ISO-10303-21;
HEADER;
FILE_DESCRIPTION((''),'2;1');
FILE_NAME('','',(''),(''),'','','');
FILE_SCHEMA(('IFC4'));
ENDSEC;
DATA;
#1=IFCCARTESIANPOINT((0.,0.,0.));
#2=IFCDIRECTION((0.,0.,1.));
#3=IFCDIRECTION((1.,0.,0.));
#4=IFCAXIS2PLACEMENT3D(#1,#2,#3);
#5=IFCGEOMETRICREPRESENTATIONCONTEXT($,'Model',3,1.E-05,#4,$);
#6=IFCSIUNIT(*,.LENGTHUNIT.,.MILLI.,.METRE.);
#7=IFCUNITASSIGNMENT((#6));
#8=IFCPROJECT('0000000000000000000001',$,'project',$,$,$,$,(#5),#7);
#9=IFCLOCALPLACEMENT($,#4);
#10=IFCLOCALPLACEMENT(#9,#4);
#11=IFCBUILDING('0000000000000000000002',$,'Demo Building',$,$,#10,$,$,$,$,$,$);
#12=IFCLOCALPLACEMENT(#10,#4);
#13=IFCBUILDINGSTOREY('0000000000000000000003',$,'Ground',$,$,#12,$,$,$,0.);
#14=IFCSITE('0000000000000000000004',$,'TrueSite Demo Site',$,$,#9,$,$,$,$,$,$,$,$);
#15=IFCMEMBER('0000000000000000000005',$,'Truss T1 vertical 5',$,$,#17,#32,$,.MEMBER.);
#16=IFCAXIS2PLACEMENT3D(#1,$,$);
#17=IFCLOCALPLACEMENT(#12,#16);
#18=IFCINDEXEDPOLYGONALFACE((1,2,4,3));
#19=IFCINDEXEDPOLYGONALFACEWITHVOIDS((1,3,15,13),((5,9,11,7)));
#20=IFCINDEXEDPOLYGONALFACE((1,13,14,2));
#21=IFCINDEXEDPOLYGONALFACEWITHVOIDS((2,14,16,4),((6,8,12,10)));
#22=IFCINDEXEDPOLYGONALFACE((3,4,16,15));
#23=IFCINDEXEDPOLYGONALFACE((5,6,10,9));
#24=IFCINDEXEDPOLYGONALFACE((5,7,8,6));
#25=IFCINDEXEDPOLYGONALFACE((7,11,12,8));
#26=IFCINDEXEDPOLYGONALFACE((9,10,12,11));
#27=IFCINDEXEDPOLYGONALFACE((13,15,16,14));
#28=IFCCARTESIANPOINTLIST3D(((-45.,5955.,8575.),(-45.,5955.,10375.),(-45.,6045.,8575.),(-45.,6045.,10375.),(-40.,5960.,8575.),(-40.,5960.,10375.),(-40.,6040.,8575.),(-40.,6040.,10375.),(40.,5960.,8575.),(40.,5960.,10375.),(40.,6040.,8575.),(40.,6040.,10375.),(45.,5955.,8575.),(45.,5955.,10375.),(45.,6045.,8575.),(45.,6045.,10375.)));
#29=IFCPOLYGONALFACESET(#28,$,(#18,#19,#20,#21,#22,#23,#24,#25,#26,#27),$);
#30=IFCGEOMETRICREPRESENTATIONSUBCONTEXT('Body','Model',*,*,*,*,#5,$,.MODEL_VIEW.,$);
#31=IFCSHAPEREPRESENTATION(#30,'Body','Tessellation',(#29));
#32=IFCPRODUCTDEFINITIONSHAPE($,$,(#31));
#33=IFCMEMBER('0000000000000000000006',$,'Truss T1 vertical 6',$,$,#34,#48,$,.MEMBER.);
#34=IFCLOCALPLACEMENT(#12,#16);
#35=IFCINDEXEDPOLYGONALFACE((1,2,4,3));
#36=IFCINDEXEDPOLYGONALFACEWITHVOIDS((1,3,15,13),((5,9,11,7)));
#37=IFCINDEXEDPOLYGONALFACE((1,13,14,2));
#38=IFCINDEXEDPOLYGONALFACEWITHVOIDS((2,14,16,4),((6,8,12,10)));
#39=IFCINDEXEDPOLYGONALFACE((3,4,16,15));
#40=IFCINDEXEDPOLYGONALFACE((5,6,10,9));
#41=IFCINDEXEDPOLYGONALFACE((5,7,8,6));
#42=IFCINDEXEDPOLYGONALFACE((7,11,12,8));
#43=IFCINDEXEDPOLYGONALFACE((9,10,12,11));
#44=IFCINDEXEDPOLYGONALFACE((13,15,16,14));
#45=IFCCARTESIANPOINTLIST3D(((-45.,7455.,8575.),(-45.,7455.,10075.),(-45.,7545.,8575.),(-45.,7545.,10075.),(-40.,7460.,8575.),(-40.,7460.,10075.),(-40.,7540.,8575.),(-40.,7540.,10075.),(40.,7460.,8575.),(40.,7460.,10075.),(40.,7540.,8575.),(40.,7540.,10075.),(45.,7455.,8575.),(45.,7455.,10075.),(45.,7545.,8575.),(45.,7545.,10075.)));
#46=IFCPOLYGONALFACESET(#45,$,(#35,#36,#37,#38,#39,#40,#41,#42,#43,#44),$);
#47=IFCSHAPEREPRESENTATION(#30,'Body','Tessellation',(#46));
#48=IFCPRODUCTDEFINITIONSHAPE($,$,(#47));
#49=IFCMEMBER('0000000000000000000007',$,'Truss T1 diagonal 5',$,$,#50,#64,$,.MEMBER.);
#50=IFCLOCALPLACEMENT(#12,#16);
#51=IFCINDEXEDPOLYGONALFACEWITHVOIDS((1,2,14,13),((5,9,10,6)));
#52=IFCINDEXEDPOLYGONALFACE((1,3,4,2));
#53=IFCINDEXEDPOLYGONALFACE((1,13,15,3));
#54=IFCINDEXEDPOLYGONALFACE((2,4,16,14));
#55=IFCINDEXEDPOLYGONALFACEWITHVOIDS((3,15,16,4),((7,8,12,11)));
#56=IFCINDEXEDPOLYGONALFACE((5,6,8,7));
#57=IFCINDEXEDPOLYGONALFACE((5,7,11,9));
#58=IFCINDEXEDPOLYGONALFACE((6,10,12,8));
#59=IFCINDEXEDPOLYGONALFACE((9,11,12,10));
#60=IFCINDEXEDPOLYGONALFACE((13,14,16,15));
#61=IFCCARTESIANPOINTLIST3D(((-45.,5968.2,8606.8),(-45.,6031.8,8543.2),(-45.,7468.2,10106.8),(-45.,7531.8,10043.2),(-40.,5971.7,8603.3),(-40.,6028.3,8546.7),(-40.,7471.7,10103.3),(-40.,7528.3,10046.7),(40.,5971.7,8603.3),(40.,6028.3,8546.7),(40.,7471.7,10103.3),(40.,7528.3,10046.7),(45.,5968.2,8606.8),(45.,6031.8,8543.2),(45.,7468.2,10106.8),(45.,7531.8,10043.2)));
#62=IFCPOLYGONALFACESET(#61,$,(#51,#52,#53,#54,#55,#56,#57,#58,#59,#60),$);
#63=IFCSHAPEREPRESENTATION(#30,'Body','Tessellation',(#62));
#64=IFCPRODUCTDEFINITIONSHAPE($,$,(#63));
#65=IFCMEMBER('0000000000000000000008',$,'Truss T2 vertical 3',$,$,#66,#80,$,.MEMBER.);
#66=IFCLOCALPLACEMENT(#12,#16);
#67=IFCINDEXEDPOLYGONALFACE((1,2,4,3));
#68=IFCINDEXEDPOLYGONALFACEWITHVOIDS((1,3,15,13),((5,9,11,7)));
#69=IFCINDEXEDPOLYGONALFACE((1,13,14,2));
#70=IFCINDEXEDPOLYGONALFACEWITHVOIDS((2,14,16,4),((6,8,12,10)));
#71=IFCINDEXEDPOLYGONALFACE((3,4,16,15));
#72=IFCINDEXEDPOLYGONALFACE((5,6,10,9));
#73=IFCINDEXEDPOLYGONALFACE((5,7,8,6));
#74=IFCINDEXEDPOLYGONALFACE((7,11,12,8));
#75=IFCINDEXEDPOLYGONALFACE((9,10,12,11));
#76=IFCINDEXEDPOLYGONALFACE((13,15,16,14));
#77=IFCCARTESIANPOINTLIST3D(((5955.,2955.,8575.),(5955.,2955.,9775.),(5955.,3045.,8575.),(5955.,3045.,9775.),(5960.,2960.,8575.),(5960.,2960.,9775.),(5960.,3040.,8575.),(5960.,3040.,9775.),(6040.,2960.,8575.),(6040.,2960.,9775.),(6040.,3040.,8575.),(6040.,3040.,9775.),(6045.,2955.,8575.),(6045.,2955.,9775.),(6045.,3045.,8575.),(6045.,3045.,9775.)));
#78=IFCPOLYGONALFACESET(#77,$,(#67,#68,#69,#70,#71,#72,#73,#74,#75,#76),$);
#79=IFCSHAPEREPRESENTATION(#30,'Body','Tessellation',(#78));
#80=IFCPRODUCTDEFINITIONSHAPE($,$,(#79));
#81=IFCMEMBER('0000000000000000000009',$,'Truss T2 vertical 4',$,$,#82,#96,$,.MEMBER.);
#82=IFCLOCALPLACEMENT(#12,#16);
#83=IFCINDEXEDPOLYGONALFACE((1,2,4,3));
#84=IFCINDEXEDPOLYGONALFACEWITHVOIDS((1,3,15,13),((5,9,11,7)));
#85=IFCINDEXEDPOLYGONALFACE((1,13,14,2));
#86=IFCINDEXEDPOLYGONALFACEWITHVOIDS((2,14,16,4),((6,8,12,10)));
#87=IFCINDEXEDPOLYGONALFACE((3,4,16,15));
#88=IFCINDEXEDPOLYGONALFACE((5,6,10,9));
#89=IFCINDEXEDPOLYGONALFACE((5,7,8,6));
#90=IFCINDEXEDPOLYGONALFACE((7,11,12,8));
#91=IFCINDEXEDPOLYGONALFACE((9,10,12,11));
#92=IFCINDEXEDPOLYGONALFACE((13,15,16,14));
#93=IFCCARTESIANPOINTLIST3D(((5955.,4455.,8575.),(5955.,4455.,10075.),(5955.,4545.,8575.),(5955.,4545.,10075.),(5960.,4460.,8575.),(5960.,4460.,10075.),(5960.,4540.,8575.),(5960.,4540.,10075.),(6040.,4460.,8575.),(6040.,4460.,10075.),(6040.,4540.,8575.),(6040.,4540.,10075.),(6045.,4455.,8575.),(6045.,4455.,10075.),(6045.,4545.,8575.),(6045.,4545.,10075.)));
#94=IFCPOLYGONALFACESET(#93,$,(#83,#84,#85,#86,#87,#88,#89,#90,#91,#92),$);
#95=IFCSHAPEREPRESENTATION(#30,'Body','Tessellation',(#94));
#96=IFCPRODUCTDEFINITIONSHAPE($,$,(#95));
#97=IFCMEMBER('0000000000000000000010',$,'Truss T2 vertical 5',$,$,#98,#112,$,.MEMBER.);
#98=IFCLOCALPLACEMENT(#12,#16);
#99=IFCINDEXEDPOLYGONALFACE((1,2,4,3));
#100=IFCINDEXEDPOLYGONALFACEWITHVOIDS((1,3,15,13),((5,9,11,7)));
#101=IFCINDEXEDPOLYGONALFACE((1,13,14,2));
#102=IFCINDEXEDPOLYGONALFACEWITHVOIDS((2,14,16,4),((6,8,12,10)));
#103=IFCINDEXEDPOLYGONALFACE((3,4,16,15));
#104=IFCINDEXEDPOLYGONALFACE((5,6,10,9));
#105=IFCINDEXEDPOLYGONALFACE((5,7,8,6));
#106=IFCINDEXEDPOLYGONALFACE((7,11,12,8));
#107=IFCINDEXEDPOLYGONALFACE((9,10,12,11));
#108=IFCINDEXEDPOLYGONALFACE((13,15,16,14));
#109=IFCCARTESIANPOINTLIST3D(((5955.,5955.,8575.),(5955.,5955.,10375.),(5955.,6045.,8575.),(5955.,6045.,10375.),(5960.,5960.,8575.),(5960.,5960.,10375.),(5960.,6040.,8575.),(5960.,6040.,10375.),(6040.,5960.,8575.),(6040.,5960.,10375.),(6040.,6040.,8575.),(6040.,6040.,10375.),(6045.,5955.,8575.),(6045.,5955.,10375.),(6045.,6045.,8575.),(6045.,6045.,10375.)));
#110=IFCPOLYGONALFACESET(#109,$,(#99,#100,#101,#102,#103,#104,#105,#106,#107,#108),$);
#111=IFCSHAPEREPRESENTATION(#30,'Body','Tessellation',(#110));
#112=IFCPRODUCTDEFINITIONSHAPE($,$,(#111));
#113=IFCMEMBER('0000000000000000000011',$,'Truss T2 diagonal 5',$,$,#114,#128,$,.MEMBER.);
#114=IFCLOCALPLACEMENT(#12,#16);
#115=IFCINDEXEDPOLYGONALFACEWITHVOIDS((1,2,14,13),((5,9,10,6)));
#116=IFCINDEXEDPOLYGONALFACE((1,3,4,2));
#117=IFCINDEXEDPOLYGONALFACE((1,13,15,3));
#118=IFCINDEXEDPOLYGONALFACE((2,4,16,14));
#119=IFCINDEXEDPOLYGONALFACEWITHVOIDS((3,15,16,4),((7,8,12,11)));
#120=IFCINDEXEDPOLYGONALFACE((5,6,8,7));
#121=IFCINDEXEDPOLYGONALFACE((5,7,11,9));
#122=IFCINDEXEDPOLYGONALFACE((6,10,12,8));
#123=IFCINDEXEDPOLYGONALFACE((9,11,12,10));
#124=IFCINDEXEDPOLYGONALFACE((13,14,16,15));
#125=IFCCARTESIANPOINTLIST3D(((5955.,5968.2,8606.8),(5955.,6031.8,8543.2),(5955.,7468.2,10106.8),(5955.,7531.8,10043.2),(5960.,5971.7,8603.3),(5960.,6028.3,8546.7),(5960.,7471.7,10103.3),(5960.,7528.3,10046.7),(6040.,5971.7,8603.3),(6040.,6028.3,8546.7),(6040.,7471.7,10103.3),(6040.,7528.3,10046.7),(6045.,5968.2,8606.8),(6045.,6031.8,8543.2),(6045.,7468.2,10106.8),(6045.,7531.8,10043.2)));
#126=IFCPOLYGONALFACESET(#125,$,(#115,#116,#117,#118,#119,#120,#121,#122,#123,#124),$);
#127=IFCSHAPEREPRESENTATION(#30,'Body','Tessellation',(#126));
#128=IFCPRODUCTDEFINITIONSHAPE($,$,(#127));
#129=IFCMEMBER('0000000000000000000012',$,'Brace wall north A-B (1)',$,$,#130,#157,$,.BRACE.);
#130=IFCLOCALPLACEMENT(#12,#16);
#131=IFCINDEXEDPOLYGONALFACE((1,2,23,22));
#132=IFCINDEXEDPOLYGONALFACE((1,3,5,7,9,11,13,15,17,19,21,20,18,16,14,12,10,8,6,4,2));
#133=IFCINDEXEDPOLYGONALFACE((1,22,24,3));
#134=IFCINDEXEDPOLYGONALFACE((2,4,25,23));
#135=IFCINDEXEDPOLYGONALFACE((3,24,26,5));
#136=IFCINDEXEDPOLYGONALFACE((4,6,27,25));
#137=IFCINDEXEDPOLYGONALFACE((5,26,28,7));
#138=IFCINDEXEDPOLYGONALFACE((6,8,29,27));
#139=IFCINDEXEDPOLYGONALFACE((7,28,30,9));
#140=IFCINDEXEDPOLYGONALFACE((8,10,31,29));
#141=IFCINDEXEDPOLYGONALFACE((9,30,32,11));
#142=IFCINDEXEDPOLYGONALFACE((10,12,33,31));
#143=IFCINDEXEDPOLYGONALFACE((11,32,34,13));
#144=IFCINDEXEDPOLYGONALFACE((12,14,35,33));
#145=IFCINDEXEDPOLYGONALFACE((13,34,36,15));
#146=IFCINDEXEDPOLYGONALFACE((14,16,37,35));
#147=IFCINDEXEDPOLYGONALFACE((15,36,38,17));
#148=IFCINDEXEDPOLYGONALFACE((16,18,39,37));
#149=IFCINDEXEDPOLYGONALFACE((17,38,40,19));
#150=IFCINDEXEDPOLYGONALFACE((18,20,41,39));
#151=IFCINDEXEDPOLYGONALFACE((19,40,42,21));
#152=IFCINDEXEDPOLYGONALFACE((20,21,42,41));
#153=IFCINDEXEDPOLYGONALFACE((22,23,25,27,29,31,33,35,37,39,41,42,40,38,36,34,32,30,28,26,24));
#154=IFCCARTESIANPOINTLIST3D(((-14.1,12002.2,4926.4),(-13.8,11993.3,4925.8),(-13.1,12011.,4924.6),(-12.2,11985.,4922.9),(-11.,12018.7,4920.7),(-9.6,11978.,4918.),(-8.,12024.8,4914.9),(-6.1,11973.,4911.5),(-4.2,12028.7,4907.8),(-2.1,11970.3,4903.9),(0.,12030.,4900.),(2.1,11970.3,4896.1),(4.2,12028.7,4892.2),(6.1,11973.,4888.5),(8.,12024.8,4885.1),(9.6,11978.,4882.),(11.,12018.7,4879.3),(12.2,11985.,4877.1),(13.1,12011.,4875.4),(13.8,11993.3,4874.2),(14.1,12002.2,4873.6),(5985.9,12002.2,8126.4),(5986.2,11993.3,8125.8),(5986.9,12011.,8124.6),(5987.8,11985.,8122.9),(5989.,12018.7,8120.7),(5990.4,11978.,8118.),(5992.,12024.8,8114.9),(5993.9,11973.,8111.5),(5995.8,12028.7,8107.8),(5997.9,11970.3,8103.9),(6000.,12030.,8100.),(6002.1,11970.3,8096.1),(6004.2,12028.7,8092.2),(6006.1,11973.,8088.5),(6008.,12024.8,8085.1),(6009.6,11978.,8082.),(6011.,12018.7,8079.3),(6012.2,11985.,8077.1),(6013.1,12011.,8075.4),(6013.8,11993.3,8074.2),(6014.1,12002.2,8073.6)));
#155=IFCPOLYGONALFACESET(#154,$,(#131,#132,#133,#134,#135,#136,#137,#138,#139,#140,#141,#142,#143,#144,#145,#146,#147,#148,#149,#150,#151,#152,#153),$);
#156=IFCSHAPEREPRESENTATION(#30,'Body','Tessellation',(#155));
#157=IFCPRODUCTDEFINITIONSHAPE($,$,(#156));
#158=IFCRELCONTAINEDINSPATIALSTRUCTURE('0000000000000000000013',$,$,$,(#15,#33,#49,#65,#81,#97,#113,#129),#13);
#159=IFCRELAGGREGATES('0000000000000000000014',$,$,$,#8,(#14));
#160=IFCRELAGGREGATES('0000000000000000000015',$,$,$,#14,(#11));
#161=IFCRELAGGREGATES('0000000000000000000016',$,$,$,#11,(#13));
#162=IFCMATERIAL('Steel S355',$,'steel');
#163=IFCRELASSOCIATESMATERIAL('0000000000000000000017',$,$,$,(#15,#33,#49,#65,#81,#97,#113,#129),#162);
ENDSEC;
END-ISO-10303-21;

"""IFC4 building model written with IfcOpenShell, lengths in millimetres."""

from ifc_helpers import new_model, si_unit, frame, origin_with_axes, place, context, subcontext, project, spatial, hollow_rectangle, circle, extrude, material, element, save


model = new_model("IFC4")

# Units and contexts
model_context = context("Model", 3, precision=1e-05, world=origin_with_axes())
body_context = subcontext(model_context, "Body", "Model", "MODEL_VIEW")
ifc_project = project(units=[si_unit("LENGTHUNIT", "METRE", prefix="MILLI")], contexts=[model_context])

# Site, building, storey
site_placement = place(None, origin_with_axes())
site = spatial("IfcSite", under=ifc_project, at=site_placement, Name="TrueSite Demo Site")
building_placement = place(site_placement, origin_with_axes())
building = spatial("IfcBuilding", under=site, at=building_placement, Name="Demo Building")
storey_placement = place(building_placement, origin_with_axes())
storey = spatial("IfcBuildingStorey", under=building, at=storey_placement, Name="Ground", Elevation=0.0)

# Shared definitions
ifc_material_1 = material(Name="Steel S355", Category="steel")

# Members
member_1_placement = place(storey_placement, frame((0.0, 6000.0, 8575.0), z_axis=(0.0, 0.0, 1.0), x_axis=(1.0, 0.0, 0.0)))
element("IfcMember", 1, at=member_1_placement, inside=storey, material=ifc_material_1, Name="Truss T1 vertical 5", PredefinedType="MEMBER", context=body_context, shape_type="SweptSolid", body=[
    extrude(hollow_rectangle(XDim=90.0, YDim=90.0, WallThickness=5.0), origin_with_axes(), (0.0, 0.0, 1.0), 1800.0),
])
member_2_placement = place(storey_placement, frame((0.0, 7500.0, 8575.0), z_axis=(0.0, 0.0, 1.0), x_axis=(1.0, 0.0, 0.0)))
element("IfcMember", 2, at=member_2_placement, inside=storey, material=ifc_material_1, Name="Truss T1 vertical 6", PredefinedType="MEMBER", context=body_context, shape_type="SweptSolid", body=[
    extrude(hollow_rectangle(XDim=90.0, YDim=90.0, WallThickness=5.0), origin_with_axes(), (0.0, 0.0, 1.0), 1500.0),
])
member_3_placement = place(storey_placement, frame((0.0, 6000.0, 8575.0), z_axis=(0.0, 0.707107, 0.707107), x_axis=(-1.0, 0.0, 0.0)))
element("IfcMember", 3, at=member_3_placement, inside=storey, material=ifc_material_1, Name="Truss T1 diagonal 5", PredefinedType="MEMBER", context=body_context, shape_type="SweptSolid", body=[
    extrude(hollow_rectangle(XDim=90.0, YDim=90.0, WallThickness=5.0), origin_with_axes(), (0.0, 0.0, 1.0), 2121.3),
])
member_4_placement = place(storey_placement, frame((6000.0, 3000.0, 8575.0), z_axis=(0.0, 0.0, 1.0), x_axis=(1.0, 0.0, 0.0)))
element("IfcMember", 4, at=member_4_placement, inside=storey, material=ifc_material_1, Name="Truss T2 vertical 3", PredefinedType="MEMBER", context=body_context, shape_type="SweptSolid", body=[
    extrude(hollow_rectangle(XDim=90.0, YDim=90.0, WallThickness=5.0), origin_with_axes(), (0.0, 0.0, 1.0), 1200.0),
])
member_5_placement = place(storey_placement, frame((6000.0, 4500.0, 8575.0), z_axis=(0.0, 0.0, 1.0), x_axis=(1.0, 0.0, 0.0)))
element("IfcMember", 5, at=member_5_placement, inside=storey, material=ifc_material_1, Name="Truss T2 vertical 4", PredefinedType="MEMBER", context=body_context, shape_type="SweptSolid", body=[
    extrude(hollow_rectangle(XDim=90.0, YDim=90.0, WallThickness=5.0), origin_with_axes(), (0.0, 0.0, 1.0), 1500.0),
])
member_6_placement = place(storey_placement, frame((6000.0, 6000.0, 8575.0), z_axis=(0.0, 0.0, 1.0), x_axis=(1.0, 0.0, 0.0)))
element("IfcMember", 6, at=member_6_placement, inside=storey, material=ifc_material_1, Name="Truss T2 vertical 5", PredefinedType="MEMBER", context=body_context, shape_type="SweptSolid", body=[
    extrude(hollow_rectangle(XDim=90.0, YDim=90.0, WallThickness=5.0), origin_with_axes(), (0.0, 0.0, 1.0), 1800.0),
])
member_7_placement = place(storey_placement, frame((6000.0, 6000.0, 8575.0), z_axis=(0.0, 0.707107, 0.707107), x_axis=(-1.0, 0.0, 0.0)))
element("IfcMember", 7, at=member_7_placement, inside=storey, material=ifc_material_1, Name="Truss T2 diagonal 5", PredefinedType="MEMBER", context=body_context, shape_type="SweptSolid", body=[
    extrude(hollow_rectangle(XDim=90.0, YDim=90.0, WallThickness=5.0), origin_with_axes(), (0.0, 0.0, 1.0), 2121.3),
])
member_8_placement = place(storey_placement, frame((0.0, 12000.0, 4900.0), z_axis=(0.882353, 0.0, 0.470588), x_axis=(0.0, 1.0, 0.0)))
element("IfcMember", 8, at=member_8_placement, inside=storey, material=ifc_material_1, Name="Brace wall north A-B (1)", PredefinedType="BRACE", context=body_context, shape_type="SweptSolid", body=[
    extrude(circle(Radius=30.0), origin_with_axes(), (0.0, 0.0, 1.0), 6800.0),
])

save(model, "model.ifc")
